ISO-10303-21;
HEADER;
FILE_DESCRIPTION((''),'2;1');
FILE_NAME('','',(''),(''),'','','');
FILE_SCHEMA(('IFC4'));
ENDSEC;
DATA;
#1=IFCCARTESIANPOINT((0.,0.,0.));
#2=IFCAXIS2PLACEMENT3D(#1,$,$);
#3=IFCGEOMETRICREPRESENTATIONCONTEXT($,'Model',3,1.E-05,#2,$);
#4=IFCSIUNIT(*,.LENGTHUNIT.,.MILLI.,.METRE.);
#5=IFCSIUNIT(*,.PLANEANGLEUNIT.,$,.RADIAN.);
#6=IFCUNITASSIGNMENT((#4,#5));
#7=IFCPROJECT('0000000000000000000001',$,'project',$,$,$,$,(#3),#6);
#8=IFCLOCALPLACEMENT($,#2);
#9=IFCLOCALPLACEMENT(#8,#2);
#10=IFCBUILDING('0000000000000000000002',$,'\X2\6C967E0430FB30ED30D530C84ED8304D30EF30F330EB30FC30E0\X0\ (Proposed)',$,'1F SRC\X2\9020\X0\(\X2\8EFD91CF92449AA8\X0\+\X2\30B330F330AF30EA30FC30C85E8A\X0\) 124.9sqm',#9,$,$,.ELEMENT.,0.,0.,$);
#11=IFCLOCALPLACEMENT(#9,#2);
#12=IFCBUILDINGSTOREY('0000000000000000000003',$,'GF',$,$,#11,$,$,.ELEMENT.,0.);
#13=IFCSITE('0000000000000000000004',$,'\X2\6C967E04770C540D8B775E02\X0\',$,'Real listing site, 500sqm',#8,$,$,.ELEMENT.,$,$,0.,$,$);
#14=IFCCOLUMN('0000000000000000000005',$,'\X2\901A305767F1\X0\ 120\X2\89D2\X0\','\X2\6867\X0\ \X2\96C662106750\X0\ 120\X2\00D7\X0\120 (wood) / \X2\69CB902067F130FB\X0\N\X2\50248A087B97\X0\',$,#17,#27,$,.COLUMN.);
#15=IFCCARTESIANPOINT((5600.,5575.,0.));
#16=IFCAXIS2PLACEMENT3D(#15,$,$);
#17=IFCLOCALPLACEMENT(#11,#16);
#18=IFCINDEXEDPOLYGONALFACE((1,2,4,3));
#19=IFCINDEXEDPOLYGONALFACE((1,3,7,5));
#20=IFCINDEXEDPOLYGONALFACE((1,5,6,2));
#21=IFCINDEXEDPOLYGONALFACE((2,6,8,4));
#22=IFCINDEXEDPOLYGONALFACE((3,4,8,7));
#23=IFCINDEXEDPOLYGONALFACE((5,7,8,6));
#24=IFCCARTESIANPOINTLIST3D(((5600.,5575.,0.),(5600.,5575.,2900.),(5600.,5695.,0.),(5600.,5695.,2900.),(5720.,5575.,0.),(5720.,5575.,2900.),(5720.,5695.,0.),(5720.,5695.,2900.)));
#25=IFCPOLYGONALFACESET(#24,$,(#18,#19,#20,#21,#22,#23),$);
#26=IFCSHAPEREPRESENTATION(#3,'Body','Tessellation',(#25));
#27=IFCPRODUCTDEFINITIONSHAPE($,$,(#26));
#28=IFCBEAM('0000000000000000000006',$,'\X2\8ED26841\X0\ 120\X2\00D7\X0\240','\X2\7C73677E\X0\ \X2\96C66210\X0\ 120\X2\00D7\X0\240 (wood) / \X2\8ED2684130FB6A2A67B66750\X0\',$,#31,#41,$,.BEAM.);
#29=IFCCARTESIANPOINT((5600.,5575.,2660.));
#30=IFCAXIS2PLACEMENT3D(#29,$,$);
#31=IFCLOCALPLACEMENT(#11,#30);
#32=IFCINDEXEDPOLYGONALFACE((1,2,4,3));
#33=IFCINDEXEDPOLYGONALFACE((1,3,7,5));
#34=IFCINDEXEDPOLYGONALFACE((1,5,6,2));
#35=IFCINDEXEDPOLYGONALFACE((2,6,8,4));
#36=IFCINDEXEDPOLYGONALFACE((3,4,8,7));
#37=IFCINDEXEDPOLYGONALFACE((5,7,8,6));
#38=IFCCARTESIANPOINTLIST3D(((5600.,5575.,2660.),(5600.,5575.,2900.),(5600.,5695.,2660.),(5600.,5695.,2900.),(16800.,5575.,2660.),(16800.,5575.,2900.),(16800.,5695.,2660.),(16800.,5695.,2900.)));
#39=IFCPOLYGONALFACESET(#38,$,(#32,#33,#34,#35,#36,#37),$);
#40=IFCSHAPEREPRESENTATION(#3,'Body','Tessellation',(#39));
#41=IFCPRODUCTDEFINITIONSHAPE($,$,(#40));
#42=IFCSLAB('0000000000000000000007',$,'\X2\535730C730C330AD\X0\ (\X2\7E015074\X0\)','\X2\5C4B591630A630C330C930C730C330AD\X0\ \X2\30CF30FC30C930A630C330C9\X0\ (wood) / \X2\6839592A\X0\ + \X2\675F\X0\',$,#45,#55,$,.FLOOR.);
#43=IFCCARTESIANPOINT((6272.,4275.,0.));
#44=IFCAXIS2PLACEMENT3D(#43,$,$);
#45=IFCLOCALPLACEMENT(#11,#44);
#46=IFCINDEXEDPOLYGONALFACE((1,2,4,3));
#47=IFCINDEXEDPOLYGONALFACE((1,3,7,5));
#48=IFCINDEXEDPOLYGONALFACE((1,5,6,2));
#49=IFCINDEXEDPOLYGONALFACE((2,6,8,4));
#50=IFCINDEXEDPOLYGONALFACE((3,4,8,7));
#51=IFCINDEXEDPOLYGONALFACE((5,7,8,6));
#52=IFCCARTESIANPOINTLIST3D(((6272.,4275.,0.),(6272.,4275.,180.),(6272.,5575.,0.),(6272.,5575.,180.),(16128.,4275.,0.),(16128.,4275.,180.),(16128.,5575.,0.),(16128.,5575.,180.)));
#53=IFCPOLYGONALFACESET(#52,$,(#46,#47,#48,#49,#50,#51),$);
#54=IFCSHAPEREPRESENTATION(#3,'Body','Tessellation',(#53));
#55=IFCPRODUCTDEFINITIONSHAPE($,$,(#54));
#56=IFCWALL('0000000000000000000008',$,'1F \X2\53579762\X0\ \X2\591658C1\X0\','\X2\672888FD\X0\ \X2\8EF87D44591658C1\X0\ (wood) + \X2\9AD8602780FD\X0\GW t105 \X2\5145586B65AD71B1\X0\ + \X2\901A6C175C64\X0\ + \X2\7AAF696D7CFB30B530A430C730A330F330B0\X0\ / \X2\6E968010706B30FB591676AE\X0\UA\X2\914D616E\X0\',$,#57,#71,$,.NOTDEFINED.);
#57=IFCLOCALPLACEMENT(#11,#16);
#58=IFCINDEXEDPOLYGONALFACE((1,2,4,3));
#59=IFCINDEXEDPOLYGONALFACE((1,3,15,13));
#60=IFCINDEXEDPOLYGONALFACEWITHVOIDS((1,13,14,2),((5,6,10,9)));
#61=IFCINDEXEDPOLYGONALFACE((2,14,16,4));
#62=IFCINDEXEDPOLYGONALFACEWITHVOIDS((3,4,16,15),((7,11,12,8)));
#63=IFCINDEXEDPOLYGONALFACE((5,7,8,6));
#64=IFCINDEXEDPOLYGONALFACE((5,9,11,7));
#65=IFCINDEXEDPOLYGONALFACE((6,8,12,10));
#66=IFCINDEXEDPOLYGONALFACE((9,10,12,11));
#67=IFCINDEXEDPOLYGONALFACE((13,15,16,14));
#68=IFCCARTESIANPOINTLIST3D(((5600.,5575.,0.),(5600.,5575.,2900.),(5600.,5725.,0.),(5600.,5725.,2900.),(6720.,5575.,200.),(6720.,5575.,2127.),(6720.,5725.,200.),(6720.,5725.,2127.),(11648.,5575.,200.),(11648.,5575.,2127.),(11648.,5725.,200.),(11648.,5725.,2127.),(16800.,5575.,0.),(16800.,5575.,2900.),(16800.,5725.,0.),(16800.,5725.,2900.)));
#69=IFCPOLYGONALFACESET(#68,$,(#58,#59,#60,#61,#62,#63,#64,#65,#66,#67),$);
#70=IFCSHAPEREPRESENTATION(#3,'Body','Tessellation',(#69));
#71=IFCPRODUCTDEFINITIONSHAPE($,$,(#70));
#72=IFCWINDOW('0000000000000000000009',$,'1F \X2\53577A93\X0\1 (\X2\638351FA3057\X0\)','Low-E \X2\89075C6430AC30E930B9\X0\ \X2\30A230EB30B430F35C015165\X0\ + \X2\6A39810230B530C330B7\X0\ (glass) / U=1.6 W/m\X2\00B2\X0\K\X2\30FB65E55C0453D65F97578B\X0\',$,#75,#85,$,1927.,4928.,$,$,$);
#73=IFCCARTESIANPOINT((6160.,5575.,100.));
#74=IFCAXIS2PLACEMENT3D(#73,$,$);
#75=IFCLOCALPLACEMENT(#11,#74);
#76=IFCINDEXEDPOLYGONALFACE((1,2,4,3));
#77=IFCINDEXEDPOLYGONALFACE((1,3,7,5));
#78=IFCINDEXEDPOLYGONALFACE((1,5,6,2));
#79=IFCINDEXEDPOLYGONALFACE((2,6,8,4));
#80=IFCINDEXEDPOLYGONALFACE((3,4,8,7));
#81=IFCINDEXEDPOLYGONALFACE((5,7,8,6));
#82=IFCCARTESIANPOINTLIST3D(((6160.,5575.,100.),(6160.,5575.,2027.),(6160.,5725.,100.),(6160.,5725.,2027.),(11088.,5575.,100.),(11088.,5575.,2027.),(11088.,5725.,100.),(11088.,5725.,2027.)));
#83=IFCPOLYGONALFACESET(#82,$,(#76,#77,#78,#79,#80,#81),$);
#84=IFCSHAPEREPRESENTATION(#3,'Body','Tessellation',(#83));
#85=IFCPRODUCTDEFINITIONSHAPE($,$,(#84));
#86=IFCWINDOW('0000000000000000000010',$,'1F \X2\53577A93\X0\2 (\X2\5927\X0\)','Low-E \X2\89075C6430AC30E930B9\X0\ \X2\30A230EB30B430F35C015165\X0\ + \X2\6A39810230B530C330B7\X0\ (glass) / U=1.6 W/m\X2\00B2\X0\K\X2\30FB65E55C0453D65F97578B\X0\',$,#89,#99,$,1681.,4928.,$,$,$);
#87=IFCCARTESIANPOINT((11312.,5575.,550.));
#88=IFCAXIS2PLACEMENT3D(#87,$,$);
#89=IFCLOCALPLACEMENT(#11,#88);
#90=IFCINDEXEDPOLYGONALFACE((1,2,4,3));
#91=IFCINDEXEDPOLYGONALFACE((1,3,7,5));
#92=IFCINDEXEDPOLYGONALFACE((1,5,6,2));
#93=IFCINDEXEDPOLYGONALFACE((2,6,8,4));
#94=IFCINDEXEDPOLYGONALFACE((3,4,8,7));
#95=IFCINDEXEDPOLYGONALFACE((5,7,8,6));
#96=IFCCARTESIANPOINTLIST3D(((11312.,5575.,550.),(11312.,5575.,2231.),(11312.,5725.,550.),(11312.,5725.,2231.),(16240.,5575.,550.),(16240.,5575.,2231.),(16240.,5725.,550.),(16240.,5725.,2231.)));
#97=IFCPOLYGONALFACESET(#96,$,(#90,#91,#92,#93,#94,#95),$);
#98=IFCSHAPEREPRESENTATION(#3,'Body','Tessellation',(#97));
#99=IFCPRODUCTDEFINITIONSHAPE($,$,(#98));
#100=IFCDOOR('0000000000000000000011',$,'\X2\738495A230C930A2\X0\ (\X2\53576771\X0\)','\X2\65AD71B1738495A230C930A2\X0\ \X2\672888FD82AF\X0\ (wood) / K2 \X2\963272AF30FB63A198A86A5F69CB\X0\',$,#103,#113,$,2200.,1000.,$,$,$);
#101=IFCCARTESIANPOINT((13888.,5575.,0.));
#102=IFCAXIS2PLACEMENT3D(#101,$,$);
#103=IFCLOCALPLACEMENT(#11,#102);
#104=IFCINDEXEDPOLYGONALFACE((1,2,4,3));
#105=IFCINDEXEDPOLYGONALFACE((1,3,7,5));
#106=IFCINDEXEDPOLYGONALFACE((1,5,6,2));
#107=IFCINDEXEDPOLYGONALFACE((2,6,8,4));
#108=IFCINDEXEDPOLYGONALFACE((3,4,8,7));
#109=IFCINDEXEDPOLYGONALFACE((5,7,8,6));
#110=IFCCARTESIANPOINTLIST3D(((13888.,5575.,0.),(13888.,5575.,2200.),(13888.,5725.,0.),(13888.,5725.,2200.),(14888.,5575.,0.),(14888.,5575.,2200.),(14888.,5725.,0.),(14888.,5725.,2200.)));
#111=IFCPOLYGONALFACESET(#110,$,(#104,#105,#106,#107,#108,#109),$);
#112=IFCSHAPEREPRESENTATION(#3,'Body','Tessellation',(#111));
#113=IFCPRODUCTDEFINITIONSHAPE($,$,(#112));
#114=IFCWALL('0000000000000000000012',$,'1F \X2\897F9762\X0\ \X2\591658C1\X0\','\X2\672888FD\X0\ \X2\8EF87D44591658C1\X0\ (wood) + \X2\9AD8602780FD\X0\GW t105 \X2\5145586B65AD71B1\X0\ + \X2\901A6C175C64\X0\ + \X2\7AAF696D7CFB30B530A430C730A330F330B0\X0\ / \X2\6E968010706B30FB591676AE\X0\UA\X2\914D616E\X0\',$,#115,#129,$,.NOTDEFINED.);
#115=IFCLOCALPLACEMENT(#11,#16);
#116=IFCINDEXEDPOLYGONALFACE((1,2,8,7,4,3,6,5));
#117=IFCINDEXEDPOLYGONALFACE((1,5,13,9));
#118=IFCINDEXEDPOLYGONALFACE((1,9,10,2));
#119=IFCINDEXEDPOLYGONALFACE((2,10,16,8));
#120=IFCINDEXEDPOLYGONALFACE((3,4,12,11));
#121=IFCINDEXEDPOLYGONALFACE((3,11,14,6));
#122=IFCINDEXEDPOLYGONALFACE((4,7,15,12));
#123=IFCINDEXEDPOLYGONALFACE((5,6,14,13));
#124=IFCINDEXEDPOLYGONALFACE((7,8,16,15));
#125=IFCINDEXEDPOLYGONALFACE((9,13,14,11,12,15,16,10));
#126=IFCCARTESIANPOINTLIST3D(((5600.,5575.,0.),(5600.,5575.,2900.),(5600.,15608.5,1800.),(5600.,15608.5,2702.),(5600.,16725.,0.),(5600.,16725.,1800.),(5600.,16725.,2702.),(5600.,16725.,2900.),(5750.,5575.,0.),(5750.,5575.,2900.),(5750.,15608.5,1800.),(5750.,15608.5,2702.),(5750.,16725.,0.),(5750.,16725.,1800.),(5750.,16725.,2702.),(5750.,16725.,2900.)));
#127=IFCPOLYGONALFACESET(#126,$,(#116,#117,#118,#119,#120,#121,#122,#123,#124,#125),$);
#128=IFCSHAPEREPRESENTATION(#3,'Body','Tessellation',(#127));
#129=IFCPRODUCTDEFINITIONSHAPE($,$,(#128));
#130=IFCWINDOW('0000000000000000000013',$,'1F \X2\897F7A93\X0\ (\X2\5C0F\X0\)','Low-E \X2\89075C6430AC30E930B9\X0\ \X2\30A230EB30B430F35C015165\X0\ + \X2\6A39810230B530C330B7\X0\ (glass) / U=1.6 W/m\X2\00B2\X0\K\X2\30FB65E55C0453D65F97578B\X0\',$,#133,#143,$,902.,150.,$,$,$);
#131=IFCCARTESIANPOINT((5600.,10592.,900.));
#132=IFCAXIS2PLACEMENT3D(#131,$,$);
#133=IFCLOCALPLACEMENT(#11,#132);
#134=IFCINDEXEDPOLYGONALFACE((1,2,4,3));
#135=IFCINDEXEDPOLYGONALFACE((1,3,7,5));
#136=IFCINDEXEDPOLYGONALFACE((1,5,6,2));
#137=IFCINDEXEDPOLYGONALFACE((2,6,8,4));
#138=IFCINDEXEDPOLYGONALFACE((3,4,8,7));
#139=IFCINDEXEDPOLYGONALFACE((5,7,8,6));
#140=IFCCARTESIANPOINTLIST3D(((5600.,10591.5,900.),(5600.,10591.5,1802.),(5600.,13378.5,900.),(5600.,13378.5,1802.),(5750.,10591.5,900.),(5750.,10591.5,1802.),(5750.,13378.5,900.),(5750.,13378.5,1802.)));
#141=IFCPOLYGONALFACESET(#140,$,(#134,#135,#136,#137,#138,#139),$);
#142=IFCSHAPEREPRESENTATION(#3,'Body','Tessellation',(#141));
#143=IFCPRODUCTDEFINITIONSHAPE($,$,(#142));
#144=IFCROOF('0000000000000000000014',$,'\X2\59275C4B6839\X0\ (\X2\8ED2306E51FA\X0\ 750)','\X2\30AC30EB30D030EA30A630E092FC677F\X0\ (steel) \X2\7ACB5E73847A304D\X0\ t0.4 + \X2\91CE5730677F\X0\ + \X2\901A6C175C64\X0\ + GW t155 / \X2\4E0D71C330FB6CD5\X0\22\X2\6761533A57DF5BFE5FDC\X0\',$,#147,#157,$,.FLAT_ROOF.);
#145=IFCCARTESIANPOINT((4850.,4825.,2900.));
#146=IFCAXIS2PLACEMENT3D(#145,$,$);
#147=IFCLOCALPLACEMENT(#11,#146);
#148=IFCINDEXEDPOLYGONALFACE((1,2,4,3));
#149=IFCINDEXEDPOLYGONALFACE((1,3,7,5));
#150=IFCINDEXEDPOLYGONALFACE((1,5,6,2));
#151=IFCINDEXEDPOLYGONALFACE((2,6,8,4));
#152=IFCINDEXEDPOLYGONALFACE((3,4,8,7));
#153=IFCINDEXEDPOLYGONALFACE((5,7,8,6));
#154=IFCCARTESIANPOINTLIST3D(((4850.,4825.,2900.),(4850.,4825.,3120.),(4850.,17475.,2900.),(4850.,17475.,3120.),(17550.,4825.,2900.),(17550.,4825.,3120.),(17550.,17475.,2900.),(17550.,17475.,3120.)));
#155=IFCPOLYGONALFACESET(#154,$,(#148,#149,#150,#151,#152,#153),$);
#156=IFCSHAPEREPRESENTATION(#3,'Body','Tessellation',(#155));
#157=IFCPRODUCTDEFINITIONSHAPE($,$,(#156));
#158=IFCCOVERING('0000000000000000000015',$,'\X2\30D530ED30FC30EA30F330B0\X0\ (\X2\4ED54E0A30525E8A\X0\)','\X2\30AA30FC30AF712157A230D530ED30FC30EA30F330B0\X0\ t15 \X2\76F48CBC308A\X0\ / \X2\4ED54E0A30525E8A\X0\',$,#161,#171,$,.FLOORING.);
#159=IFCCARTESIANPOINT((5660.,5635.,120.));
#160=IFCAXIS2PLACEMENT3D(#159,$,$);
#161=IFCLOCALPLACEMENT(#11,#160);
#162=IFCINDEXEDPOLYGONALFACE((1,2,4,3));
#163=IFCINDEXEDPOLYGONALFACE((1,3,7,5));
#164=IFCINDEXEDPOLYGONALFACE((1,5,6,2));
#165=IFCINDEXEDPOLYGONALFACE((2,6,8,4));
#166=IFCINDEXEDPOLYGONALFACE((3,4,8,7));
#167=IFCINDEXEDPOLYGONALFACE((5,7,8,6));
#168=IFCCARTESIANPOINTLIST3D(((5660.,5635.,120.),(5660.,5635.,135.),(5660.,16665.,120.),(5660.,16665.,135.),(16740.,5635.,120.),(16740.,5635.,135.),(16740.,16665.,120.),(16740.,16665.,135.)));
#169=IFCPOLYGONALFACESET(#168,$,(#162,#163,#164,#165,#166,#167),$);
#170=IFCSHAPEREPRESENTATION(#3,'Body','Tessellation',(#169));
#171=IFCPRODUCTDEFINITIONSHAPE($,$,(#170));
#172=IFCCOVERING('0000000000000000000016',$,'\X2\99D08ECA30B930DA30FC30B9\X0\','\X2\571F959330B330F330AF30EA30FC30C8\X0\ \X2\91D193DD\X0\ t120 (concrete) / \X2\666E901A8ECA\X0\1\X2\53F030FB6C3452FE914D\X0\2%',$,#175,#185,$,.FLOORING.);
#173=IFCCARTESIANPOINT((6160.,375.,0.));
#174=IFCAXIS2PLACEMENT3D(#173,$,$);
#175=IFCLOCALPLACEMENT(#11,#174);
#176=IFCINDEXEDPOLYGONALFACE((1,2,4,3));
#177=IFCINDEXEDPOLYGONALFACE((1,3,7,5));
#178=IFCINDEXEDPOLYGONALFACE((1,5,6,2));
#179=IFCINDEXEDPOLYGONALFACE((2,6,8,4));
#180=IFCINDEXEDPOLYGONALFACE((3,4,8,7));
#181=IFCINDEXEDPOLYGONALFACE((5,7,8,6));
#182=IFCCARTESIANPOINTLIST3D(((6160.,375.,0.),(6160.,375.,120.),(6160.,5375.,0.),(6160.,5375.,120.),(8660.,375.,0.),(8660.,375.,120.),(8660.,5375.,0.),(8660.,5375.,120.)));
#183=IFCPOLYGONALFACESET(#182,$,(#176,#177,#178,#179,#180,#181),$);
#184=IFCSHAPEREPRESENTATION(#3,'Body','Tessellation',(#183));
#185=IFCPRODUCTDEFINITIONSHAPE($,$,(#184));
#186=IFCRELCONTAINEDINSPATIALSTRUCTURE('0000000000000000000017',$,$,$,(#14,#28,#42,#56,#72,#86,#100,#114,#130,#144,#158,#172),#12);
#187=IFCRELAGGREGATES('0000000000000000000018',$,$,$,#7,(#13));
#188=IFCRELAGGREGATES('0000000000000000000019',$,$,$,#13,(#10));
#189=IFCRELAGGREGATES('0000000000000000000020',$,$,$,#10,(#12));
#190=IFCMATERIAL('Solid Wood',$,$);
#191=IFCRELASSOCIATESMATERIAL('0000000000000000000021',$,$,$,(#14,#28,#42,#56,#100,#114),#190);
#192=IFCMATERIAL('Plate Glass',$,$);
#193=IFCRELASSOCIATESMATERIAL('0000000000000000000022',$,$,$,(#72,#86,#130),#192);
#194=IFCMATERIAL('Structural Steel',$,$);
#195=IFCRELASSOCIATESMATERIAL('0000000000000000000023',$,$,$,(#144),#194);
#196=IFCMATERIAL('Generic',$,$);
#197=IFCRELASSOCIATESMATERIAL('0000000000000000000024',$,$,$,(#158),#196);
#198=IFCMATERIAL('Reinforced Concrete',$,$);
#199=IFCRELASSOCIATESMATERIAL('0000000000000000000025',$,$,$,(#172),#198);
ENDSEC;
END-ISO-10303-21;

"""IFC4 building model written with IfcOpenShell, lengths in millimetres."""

from ifc_helpers import new_model, si_unit, frame, frame_2d, origin, place, context, project, spatial, rectangle, extrude, material, element, fill, save


model = new_model("IFC4")

# Units and contexts
model_context = context("Model", 3, precision=1e-05, world=origin())
ifc_project = project(units=[si_unit("LENGTHUNIT", "METRE", prefix="MILLI"), si_unit("PLANEANGLEUNIT", "RADIAN")], contexts=[model_context])

# Site, building, storey
site_placement = place(None, origin())
site = spatial("IfcSite", under=ifc_project, at=site_placement, Name="沖縄県名護市", ObjectType="Real listing site, 500sqm", CompositionType="ELEMENT", RefElevation=0.0)
building_placement = place(site_placement, origin())
building = spatial("IfcBuilding", under=site, at=building_placement, Name="沖縄・ロフト付きワンルーム (Proposed)", ObjectType="1F SRC造(軽量鉄骨+コンクリート床) 124.9sqm", CompositionType="ELEMENT", ElevationOfRefHeight=0.0, ElevationOfTerrain=0.0)
storey_placement = place(building_placement, origin())
storey = spatial("IfcBuildingStorey", under=building, at=storey_placement, Name="GF", CompositionType="ELEMENT", Elevation=0.0)

# Column
ifc_material_1 = material(Name="Solid Wood")
column_1_placement = place(storey_placement, frame((5600.0, 5575.0, 0.0)))
element("IfcColumn", 1, at=column_1_placement, inside=storey, material=ifc_material_1, Name="通し柱 120角", Description="桧 集成材 120×120 (wood) / 構造柱・N値計算", PredefinedType="COLUMN", context=model_context, shape_type="SweptSolid", body=[
    extrude(rectangle(XDim=120.0, YDim=120.0, at=frame_2d((60.0, 60.0))), frame((5600.0, 5575.0, 0.0)), (0.0, 0.0, 1.0), 2900.0),
])

# Beam
beam_1_placement = place(storey_placement, frame((5600.0, 5575.0, 2660.0)))
element("IfcBeam", 2, at=beam_1_placement, inside=storey, material=ifc_material_1, Name="軒桁 120×240", Description="米松 集成 120×240 (wood) / 軒桁・横架材", PredefinedType="BEAM", context=model_context, shape_type="SweptSolid", body=[
    extrude(rectangle(XDim=11200.0, YDim=120.0, at=frame_2d((5600.0, 60.0))), frame((5600.0, 5575.0, 2660.0)), (0.0, 0.0, 1.0), 240.0),
])

# Slab
ifc_material_2 = material(Name="Reinforced Concrete")
slab_1_placement = place(storey_placement, frame((6272.0, 4275.0, 0.0)))
element("IfcSlab", 3, at=slab_1_placement, inside=storey, material=ifc_material_1, Name="南デッキ (縁側)", Description="屋外ウッドデッキ ハードウッド (wood) / 根太 + 束", PredefinedType="FLOOR", context=model_context, shape_type="SweptSolid", body=[
    extrude(rectangle(XDim=9856.0, YDim=1300.0, at=frame_2d((4928.0, 650.0))), frame((6272.0, 4275.0, 0.0)), (0.0, 0.0, 1.0), 180.0),
])

# Wall, openings, windows, door
wall_1_placement = place(storey_placement, frame((5600.0, 5575.0, 0.0)))
wall_1 = element("IfcWall", 4, at=wall_1_placement, inside=storey, material=ifc_material_1, Name="1F 南面 外壁", Description="木製 軸組外壁 (wood) + 高性能GW t105 充填断熱 + 通気層 + 窯業系サイディング / 準耐火・外皮UA配慮", PredefinedType="NOTDEFINED", context=model_context, shape_type="SweptSolid", body=[
    extrude(rectangle(XDim=11200.0, YDim=150.0, at=frame_2d((5600.0, 75.0))), frame((5600.0, 5575.0, 0.0)), (0.0, 0.0, 1.0), 2900.0),
])
opening_1_placement = place(storey_placement, frame((6160.0, 5575.0, 100.0)))
opening_1 = element("IfcOpeningElement", 5, at=opening_1_placement, cuts=wall_1, PredefinedType="NOTDEFINED", context=model_context, shape_type="SweptSolid", body=[
    extrude(rectangle(XDim=4928.0, YDim=150.0, at=frame_2d((2464.0, 75.0))), frame((6160.0, 5575.0, 100.0)), (0.0, 0.0, 1.0), 1927.0),
])
opening_2_placement = place(storey_placement, frame((11312.0, 5575.0, 550.0)))
opening_2 = element("IfcOpeningElement", 6, at=opening_2_placement, cuts=wall_1, PredefinedType="NOTDEFINED", context=model_context, shape_type="SweptSolid", body=[
    extrude(rectangle(XDim=4928.0, YDim=150.0, at=frame_2d((2464.0, 75.0))), frame((11312.0, 5575.0, 550.0)), (0.0, 0.0, 1.0), 1681.0),
])
opening_3_placement = place(storey_placement, frame((13888.0, 5575.0, 0.0)))
opening_3 = element("IfcOpeningElement", 7, at=opening_3_placement, cuts=wall_1, PredefinedType="NOTDEFINED", context=model_context, shape_type="SweptSolid", body=[
    extrude(rectangle(XDim=1000.0, YDim=150.0, at=frame_2d((500.0, 75.0))), frame((13888.0, 5575.0, 0.0)), (0.0, 0.0, 1.0), 2200.0),
])
ifc_material_3 = material(Name="Plate Glass")
window_1_placement = place(storey_placement, frame((6160.0, 5575.0, 100.0)))
window_1 = element("IfcWindow", 8, at=window_1_placement, inside=storey, material=ifc_material_3, Name="1F 南窓1 (掃出し)", Description="Low-E 複層ガラス アルゴン封入 + 樹脂サッシ (glass) / U=1.6 W/m²K・日射取得型", OverallHeight=1927.0, OverallWidth=4928.0, context=model_context, shape_type="SweptSolid", body=[
    extrude(rectangle(XDim=4928.0, YDim=150.0, at=frame_2d((2464.0, 75.0))), frame((6160.0, 5575.0, 100.0)), (0.0, 0.0, 1.0), 1927.0),
])
fill(opening_1, window_1)
window_2_placement = place(storey_placement, frame((11312.0, 5575.0, 550.0)))
window_2 = element("IfcWindow", 9, at=window_2_placement, inside=storey, material=ifc_material_3, Name="1F 南窓2 (大)", Description="Low-E 複層ガラス アルゴン封入 + 樹脂サッシ (glass) / U=1.6 W/m²K・日射取得型", OverallHeight=1681.0, OverallWidth=4928.0, context=model_context, shape_type="SweptSolid", body=[
    extrude(rectangle(XDim=4928.0, YDim=150.0, at=frame_2d((2464.0, 75.0))), frame((11312.0, 5575.0, 550.0)), (0.0, 0.0, 1.0), 1681.0),
])
fill(opening_2, window_2)
door_placement = place(storey_placement, frame((13888.0, 5575.0, 0.0)))
door = element("IfcDoor", 10, at=door_placement, inside=storey, material=ifc_material_1, Name="玄関ドア (南東)", Description="断熱玄関ドア 木製芯 (wood) / K2 防犯・採風機構", OverallHeight=2200.0, OverallWidth=1000.0, context=model_context, shape_type="SweptSolid", body=[
    extrude(rectangle(XDim=1000.0, YDim=150.0, at=frame_2d((500.0, 75.0))), frame((13888.0, 5575.0, 0.0)), (0.0, 0.0, 1.0), 2200.0),
])
fill(opening_3, door)

# Wall, opening, window
wall_2_placement = place(storey_placement, frame((5600.0, 5575.0, 0.0)))
wall_2 = element("IfcWall", 11, at=wall_2_placement, inside=storey, material=ifc_material_1, Name="1F 西面 外壁", Description="木製 軸組外壁 (wood) + 高性能GW t105 充填断熱 + 通気層 + 窯業系サイディング / 準耐火・外皮UA配慮", PredefinedType="NOTDEFINED", context=model_context, shape_type="SweptSolid", body=[
    extrude(rectangle(XDim=150.0, YDim=11150.0, at=frame_2d((75.0, 5575.0))), frame((5600.0, 5575.0, 0.0)), (0.0, 0.0, 1.0), 2900.0),
])
opening_4_placement = place(storey_placement, frame((5600.0, 10592.0, 900.0)))
opening_4 = element("IfcOpeningElement", 12, at=opening_4_placement, cuts=wall_2, PredefinedType="NOTDEFINED", context=model_context, shape_type="SweptSolid", body=[
    extrude(rectangle(XDim=150.0, YDim=2787.0, at=frame_2d((75.0, 1393.0))), frame((5600.0, 10592.0, 900.0)), (0.0, 0.0, 1.0), 902.0),
])
window_3_placement = place(storey_placement, frame((5600.0, 10592.0, 900.0)))
window_3 = element("IfcWindow", 13, at=window_3_placement, inside=storey, material=ifc_material_3, Name="1F 西窓 (小)", Description="Low-E 複層ガラス アルゴン封入 + 樹脂サッシ (glass) / U=1.6 W/m²K・日射取得型", OverallHeight=902.0, OverallWidth=150.0, context=model_context, shape_type="SweptSolid", body=[
    extrude(rectangle(XDim=150.0, YDim=2787.0, at=frame_2d((75.0, 1393.0))), frame((5600.0, 10592.0, 900.0)), (0.0, 0.0, 1.0), 902.0),
])
fill(opening_4, window_3)

# Roof
ifc_material_4 = material(Name="Structural Steel")
roof_placement = place(storey_placement, frame((4850.0, 4825.0, 2900.0)))
element("IfcRoof", 14, at=roof_placement, inside=storey, material=ifc_material_4, Name="大屋根 (軒の出 750)", Description="ガルバリウム鋼板 (steel) 立平葺き t0.4 + 野地板 + 通気層 + GW t155 / 不燃・法22条区域対応", PredefinedType="FLAT_ROOF", context=model_context, shape_type="SweptSolid", body=[
    extrude(rectangle(XDim=12700.0, YDim=12650.0, at=frame_2d((6350.0, 6325.0))), frame((4850.0, 4825.0, 2900.0)), (0.0, 0.0, 1.0), 220.0),
])

# Coverings
ifc_material_5 = material(Name="Generic")
covering_1_placement = place(storey_placement, frame((5660.0, 5635.0, 120.0)))
element("IfcCovering", 15, at=covering_1_placement, inside=storey, material=ifc_material_5, Name="フローリング (仕上げ床)", Description="オーク無垢フローリング t15 直貼り / 仕上げ床", PredefinedType="FLOORING", context=model_context, shape_type="SweptSolid", body=[
    extrude(rectangle(XDim=11080.0, YDim=11030.0, at=frame_2d((5540.0, 5515.0))), frame((5660.0, 5635.0, 120.0)), (0.0, 0.0, 1.0), 15.0),
])
covering_2_placement = place(storey_placement, frame((6160.0, 375.0, 0.0)))
element("IfcCovering", 16, at=covering_2_placement, inside=storey, material=ifc_material_2, Name="駐車スペース", Description="土間コンクリート 金鏝 t120 (concrete) / 普通車1台・水勾配2%", PredefinedType="FLOORING", context=model_context, shape_type="SweptSolid", body=[
    extrude(rectangle(XDim=2500.0, YDim=5000.0, at=frame_2d((1250.0, 2500.0))), frame((6160.0, 375.0, 0.0)), (0.0, 0.0, 1.0), 120.0),
])

save(model, "model.ifc")
